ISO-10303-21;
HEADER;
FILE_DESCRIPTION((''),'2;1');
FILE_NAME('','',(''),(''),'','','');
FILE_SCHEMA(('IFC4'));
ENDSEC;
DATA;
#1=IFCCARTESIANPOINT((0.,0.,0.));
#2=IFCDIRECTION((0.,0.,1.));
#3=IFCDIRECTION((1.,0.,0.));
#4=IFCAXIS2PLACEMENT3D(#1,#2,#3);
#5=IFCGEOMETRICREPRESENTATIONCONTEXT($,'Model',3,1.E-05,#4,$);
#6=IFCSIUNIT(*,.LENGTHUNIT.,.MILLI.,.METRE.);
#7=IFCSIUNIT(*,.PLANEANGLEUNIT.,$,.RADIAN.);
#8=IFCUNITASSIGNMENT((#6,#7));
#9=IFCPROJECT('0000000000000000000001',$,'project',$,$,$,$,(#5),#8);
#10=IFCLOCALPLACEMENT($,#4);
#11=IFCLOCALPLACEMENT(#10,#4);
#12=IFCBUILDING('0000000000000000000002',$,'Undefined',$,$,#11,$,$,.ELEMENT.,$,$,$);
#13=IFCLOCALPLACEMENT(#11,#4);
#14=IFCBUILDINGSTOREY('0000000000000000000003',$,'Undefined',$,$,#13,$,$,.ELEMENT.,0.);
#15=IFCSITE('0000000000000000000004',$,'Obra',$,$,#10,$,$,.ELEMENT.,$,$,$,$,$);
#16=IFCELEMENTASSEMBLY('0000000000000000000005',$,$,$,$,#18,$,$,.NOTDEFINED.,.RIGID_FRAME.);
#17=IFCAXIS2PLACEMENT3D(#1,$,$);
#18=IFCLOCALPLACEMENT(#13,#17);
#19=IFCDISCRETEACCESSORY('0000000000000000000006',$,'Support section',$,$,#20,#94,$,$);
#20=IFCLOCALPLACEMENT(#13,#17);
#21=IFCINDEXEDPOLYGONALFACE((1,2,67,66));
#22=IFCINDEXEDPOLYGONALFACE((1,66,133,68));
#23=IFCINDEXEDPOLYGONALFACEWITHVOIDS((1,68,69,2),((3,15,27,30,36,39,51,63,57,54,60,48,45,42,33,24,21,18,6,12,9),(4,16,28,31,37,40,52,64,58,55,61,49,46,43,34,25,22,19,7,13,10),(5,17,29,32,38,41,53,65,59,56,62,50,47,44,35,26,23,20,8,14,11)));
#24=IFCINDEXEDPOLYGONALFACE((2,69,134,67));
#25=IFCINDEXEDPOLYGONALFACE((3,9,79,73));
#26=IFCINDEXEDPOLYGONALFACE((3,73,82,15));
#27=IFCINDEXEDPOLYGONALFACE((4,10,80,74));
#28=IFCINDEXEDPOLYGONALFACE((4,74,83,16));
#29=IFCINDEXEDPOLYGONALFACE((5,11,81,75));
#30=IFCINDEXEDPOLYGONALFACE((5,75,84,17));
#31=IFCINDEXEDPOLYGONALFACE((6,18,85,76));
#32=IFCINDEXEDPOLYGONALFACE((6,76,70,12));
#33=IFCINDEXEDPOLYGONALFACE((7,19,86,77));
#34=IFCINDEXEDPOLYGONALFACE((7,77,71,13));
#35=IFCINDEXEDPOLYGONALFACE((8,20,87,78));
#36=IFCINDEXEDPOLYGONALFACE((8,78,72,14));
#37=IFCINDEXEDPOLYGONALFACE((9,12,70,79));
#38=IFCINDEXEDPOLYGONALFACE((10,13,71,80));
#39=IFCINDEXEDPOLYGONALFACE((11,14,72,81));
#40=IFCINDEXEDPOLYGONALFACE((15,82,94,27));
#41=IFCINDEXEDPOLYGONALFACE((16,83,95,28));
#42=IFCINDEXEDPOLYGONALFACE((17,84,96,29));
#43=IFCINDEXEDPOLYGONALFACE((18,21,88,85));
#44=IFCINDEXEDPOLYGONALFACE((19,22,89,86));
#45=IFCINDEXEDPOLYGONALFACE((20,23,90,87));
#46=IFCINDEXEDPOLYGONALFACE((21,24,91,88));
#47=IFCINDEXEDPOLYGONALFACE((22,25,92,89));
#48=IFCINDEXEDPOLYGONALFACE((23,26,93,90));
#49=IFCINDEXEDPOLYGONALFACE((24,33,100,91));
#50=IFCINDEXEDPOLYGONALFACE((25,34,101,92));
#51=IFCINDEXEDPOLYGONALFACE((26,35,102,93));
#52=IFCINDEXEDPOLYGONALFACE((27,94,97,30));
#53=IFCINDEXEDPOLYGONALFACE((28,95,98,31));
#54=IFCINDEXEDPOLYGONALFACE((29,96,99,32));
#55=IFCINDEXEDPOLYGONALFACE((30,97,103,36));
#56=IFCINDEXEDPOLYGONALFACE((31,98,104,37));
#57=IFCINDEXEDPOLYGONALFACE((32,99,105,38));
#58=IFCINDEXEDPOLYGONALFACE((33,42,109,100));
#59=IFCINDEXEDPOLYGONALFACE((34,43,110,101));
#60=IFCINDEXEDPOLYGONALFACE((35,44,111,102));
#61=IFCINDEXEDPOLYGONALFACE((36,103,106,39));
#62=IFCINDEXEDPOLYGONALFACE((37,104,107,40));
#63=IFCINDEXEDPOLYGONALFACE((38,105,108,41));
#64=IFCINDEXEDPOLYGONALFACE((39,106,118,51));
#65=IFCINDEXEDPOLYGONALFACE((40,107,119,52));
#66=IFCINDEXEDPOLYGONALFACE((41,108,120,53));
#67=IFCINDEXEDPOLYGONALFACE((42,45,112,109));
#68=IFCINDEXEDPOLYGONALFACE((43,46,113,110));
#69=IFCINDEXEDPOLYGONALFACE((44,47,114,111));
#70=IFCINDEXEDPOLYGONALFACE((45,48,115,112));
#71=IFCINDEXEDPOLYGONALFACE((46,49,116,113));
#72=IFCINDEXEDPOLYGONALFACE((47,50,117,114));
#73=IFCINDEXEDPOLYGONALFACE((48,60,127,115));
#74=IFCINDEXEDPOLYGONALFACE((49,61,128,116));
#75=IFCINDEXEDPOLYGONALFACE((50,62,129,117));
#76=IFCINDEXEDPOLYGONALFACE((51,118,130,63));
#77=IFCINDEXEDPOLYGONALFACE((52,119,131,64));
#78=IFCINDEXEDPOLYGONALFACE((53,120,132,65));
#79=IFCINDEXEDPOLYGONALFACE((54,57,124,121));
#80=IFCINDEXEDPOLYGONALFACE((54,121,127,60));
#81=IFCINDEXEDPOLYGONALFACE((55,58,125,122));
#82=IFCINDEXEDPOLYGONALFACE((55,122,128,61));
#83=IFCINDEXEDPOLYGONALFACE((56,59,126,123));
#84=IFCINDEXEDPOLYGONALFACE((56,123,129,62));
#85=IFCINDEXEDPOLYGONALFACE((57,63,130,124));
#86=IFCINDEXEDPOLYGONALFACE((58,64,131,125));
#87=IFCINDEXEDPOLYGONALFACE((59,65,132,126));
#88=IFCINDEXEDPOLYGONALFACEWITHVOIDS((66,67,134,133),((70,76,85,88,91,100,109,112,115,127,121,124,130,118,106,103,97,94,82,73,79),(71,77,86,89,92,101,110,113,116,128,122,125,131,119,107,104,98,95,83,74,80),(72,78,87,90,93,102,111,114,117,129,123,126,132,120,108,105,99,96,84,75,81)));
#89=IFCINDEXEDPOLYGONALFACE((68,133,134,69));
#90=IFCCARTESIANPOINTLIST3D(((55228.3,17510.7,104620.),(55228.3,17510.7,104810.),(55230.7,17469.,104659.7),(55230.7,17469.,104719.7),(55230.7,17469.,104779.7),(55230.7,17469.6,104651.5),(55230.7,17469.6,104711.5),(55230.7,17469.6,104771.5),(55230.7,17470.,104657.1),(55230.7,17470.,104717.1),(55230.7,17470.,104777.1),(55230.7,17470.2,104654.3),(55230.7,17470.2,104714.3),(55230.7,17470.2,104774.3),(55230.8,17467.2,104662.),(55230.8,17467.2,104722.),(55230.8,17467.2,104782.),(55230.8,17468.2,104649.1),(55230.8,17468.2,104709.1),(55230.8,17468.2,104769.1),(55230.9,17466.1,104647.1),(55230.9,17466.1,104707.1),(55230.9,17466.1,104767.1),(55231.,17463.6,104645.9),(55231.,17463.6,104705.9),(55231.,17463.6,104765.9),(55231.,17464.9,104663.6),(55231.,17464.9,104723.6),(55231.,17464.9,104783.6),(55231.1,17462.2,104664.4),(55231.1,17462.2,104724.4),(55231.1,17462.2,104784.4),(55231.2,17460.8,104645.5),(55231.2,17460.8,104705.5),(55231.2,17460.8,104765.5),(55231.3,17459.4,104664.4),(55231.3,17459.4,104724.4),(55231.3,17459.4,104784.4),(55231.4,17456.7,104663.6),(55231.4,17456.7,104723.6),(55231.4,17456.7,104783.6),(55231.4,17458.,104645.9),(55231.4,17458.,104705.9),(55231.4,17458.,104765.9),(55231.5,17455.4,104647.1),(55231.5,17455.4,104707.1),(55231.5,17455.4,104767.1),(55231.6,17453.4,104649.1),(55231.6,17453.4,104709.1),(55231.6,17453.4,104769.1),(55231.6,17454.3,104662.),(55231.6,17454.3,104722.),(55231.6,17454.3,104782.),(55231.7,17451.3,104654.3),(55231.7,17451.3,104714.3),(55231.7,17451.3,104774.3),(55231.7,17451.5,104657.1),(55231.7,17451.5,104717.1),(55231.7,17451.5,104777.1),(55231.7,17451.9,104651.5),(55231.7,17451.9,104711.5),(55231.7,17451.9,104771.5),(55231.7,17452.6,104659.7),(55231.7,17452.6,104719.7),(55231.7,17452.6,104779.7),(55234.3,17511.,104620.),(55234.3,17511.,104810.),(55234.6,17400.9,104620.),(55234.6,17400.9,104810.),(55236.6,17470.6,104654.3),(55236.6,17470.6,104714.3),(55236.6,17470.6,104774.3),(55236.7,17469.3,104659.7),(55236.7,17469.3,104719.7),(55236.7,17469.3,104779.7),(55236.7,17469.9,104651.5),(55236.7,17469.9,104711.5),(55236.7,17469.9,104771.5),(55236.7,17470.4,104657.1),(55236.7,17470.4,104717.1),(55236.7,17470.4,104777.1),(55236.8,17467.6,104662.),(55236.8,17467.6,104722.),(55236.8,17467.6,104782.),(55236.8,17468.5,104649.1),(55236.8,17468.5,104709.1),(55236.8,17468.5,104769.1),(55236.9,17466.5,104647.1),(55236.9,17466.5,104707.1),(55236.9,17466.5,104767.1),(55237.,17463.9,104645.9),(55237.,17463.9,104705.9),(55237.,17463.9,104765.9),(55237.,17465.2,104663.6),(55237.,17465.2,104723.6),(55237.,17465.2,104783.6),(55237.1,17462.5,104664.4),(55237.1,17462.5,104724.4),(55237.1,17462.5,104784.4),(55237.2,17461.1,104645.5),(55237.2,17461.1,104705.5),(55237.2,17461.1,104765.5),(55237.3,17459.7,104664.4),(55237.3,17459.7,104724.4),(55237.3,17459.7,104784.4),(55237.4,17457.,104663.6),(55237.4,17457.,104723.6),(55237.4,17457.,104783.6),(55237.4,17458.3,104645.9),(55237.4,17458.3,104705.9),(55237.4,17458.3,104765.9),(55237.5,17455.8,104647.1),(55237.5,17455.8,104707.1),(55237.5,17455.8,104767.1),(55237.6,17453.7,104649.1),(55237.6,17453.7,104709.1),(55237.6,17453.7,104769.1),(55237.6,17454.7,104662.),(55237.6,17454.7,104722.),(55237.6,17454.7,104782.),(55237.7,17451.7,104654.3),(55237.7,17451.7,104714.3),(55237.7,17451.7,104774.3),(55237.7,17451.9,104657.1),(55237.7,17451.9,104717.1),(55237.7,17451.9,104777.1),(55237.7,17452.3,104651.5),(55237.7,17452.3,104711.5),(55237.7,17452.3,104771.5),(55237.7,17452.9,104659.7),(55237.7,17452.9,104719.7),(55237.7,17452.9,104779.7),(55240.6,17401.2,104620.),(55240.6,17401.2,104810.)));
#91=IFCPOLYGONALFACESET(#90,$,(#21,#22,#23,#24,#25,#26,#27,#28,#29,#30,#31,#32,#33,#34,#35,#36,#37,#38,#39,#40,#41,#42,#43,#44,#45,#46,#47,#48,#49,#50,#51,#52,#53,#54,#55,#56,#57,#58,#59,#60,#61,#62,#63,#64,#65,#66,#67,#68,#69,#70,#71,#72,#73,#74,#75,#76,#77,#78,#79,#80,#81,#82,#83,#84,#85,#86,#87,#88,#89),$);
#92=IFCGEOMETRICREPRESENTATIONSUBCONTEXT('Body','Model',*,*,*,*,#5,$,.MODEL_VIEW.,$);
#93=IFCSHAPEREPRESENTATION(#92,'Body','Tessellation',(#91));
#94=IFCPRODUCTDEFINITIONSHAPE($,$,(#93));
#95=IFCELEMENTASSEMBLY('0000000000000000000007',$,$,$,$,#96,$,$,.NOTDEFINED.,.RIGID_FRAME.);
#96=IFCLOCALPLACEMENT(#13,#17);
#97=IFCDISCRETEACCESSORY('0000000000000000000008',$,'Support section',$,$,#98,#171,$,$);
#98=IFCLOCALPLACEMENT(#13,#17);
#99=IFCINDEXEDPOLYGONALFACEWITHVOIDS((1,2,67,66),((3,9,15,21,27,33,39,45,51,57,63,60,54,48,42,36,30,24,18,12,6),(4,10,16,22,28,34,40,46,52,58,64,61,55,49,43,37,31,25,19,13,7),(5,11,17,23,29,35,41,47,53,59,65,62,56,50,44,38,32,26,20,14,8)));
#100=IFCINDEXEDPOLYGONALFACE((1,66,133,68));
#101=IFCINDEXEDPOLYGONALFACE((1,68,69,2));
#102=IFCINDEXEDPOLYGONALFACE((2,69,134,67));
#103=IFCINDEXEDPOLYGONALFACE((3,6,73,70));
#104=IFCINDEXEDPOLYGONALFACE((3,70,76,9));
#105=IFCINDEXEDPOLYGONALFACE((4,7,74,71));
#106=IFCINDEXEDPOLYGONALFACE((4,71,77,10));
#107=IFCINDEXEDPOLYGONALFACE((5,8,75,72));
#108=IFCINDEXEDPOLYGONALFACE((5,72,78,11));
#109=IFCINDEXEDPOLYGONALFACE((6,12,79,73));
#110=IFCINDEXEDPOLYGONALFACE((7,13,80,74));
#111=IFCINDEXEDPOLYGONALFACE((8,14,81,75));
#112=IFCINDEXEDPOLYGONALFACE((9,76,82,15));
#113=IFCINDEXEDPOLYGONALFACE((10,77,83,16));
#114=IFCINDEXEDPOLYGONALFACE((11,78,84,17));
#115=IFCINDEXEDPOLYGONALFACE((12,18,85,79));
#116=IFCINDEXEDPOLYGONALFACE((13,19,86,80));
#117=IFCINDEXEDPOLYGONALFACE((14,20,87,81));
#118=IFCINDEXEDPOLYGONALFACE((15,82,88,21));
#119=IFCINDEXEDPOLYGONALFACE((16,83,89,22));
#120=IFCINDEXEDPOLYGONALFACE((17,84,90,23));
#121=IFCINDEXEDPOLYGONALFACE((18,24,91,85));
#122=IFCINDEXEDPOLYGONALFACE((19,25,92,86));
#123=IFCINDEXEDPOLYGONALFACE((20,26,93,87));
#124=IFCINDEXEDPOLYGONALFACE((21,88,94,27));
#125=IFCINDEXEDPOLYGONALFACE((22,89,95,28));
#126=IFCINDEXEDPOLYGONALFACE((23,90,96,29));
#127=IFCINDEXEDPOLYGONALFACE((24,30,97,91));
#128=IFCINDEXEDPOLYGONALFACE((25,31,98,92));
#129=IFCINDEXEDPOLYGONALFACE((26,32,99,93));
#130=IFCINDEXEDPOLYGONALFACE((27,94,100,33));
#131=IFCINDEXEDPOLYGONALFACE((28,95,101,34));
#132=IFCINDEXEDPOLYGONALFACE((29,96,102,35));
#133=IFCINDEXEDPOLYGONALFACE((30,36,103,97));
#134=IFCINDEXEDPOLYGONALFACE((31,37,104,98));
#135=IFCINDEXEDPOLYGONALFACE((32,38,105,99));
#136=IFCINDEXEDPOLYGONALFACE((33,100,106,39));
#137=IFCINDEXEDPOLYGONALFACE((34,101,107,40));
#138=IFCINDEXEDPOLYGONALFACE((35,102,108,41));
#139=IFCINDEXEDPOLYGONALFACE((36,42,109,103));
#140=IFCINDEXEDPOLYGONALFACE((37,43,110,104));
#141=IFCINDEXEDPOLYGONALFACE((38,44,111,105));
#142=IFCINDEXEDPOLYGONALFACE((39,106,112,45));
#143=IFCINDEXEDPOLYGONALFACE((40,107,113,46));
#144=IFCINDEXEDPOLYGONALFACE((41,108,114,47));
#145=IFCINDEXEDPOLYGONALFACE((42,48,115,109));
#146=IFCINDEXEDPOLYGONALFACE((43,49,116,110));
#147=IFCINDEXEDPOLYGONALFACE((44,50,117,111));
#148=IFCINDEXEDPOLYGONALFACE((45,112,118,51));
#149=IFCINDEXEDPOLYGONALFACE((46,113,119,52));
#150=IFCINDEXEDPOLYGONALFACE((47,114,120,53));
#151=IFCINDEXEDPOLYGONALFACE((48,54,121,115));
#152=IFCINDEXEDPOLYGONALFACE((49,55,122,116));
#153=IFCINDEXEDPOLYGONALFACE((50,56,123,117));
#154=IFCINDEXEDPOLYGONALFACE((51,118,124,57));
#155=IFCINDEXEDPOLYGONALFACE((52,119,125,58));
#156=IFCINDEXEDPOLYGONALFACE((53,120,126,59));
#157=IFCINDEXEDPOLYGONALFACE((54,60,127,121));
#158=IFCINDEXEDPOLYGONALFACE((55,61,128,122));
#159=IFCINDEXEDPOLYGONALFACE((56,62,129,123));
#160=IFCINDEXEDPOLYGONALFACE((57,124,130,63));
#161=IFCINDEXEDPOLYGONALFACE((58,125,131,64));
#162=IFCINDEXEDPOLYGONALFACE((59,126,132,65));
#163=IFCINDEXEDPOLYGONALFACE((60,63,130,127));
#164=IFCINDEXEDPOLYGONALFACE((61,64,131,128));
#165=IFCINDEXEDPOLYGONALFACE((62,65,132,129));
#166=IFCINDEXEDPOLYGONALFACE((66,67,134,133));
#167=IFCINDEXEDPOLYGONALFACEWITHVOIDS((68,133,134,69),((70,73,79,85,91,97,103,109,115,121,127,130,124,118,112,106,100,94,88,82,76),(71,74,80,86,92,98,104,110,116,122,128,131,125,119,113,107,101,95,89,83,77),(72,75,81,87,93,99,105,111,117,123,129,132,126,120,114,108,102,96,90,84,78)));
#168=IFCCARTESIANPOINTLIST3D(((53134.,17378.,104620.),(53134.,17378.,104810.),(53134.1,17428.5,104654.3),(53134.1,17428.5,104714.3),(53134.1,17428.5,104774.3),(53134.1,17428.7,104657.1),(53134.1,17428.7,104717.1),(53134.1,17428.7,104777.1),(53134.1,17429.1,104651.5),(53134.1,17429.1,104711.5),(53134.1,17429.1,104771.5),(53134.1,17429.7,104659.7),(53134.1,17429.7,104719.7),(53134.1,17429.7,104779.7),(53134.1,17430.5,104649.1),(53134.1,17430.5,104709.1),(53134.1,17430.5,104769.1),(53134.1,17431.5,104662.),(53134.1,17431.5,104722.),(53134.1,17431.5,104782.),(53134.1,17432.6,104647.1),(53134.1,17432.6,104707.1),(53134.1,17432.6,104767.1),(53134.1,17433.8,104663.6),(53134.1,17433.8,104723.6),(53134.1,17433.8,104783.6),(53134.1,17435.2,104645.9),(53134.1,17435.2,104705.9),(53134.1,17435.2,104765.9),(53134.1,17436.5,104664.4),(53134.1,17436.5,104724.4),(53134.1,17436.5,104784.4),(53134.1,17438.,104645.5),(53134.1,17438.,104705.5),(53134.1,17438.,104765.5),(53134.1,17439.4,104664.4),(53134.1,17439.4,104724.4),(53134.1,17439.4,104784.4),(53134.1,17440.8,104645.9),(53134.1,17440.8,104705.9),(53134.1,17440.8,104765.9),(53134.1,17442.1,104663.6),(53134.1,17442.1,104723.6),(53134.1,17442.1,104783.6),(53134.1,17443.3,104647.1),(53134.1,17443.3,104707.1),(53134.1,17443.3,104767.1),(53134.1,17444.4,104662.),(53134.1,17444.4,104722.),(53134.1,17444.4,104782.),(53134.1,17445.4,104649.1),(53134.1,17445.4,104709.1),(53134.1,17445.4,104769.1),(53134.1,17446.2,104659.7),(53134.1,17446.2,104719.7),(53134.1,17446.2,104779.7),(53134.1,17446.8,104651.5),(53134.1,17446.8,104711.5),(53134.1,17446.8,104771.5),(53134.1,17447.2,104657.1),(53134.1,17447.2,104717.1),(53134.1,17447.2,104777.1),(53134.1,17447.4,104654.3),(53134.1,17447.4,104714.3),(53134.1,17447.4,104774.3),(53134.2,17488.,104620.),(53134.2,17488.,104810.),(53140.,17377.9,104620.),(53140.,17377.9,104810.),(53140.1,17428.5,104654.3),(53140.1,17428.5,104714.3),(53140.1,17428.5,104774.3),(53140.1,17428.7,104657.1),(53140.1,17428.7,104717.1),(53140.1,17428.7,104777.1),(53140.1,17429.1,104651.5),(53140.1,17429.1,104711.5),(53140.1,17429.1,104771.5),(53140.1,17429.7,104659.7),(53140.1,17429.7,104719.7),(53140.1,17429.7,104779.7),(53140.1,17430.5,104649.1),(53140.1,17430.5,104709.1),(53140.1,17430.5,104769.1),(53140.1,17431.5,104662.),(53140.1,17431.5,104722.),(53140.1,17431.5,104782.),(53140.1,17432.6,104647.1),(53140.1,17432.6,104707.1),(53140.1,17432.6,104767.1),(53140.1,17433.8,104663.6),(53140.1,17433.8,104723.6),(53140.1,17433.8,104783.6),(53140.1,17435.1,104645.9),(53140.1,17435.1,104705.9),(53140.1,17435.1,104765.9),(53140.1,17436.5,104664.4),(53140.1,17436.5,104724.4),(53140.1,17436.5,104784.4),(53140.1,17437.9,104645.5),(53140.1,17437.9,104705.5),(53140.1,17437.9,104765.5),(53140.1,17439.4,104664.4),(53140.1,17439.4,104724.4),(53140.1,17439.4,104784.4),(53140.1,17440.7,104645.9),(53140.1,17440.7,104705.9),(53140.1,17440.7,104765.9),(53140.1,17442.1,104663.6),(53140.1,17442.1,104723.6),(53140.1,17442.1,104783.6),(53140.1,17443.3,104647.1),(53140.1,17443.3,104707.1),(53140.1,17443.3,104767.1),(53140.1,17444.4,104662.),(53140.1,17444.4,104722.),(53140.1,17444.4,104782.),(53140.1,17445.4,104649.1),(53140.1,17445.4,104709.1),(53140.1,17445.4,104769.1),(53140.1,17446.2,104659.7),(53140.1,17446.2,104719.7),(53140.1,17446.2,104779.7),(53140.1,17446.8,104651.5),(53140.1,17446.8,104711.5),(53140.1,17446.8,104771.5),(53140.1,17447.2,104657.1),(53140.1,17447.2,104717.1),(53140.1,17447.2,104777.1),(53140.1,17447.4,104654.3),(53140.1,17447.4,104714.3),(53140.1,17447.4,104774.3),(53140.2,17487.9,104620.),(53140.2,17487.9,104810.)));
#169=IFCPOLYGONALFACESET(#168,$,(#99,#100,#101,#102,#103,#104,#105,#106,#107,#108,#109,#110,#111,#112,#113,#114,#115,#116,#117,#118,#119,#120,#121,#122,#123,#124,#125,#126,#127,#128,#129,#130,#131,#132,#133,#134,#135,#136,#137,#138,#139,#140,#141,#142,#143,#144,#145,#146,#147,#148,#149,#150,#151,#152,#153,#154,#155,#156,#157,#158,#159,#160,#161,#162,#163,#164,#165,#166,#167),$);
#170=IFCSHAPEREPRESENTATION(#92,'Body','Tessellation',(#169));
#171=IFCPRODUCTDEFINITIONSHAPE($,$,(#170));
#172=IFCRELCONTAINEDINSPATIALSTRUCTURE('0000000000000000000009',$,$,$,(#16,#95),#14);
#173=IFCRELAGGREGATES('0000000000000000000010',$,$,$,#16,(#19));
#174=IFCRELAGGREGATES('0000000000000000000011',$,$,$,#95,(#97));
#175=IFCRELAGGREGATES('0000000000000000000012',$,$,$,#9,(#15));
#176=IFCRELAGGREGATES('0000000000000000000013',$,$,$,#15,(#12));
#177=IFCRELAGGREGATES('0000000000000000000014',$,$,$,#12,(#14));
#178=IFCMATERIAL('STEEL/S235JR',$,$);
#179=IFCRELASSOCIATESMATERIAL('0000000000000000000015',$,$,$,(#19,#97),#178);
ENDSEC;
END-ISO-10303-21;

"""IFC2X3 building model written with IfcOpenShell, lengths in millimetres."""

from ifc_helpers import new_model, si_unit, frame, origin_with_axes, origin_2d_with_axis, place, context, subcontext, project, spatial, rectangle, circle, extrude, source, transform, mapped, material, element, aggregate, save


model = new_model("IFC2X3")

# Units and contexts
model_context = context("Model", 3, precision=1e-05, world=origin_with_axes())
body_context = subcontext(model_context, "Body", "Model", "MODEL_VIEW")
ifc_project = project(units=[si_unit("LENGTHUNIT", "METRE", prefix="MILLI"), si_unit("PLANEANGLEUNIT", "RADIAN")], contexts=[model_context])

# Site, building, storey
site_placement = place(None, origin_with_axes())
site = spatial("IfcSite", under=ifc_project, at=site_placement, Name="Obra", CompositionType="ELEMENT")
building_placement = place(site_placement, origin_with_axes())
building = spatial("IfcBuilding", under=site, at=building_placement, Name="Undefined", CompositionType="ELEMENT")
storey_placement = place(building_placement, origin_with_axes())
storey = spatial("IfcBuildingStorey", under=building, at=storey_placement, Name="Undefined", CompositionType="ELEMENT", Elevation=0.0)

# Shared definitions
ifc_material = material(Name="STEEL/S235JR")

# Element assemblies, discrete accessories, openings
shared_shape_1 = source(origin_with_axes(), body_context, "Body", "SweptSolid", [
    extrude(circle(Radius=9.5, at=origin_2d_with_axis()), frame((0.0, -9.2, 0.0), z_axis=(0.0, 1.0, 0.0), x_axis=(1.0, 0.0, 0.0)), (0.0, 0.0, 1.0), 6.2),
])
assembly_1_placement = place(storey_placement, origin_with_axes())
assembly_1 = element("IfcElementAssembly", 1, at=assembly_1_placement, inside=storey, AssemblyPlace="NOTDEFINED", PredefinedType="RIGID_FRAME")
discrete_accessory_1_placement = place(assembly_1_placement, frame((55234.5, 17456.0, 104620.0), z_axis=(0.0, 0.0, 1.0), x_axis=(0.057107, -0.998368, 0.0)))
discrete_accessory_1 = element("IfcDiscreteAccessory", 2, at=discrete_accessory_1_placement, material=ifc_material, Name="Support section", context=body_context, shape_type="SweptSolid", body=[
    extrude(rectangle(XDim=6.0, YDim=110.0, at=origin_2d_with_axis()), frame((0.0, 0.0, 190.0), z_axis=(0.0, 0.0, -1.0), x_axis=(0.0, 1.0, 0.0)), (0.0, 0.0, 1.0), 190.0),
])
opening_1_placement = place(assembly_1_placement, frame((55231.0, 17410.7, 104835.0), z_axis=(-0.057107, 0.998368, 0.0), x_axis=(0.0, 0.0, -1.0)))
element("IfcOpeningElement", 3, at=opening_1_placement, cuts=discrete_accessory_1, ObjectType="Opening", context=body_context, shape_type="MappedRepresentation", body=[
    mapped(shared_shape_1, transform((60.0, 0.0, 50.0))),
    mapped(shared_shape_1, transform((120.0, 0.0, 50.0))),
    mapped(shared_shape_1, transform((180.0, 0.0, 50.0))),
])
aggregate(assembly_1, [discrete_accessory_1])
assembly_2_placement = place(storey_placement, origin_with_axes())
assembly_2 = element("IfcElementAssembly", 4, at=assembly_2_placement, inside=storey, AssemblyPlace="NOTDEFINED", PredefinedType="RIGID_FRAME")
discrete_accessory_2_placement = place(assembly_2_placement, frame((53137.1, 17433.0, 104620.0), z_axis=(0.0, 0.0, 1.0), x_axis=(-0.001649, -0.999999, 0.0)))
discrete_accessory_2 = element("IfcDiscreteAccessory", 5, at=discrete_accessory_2_placement, material=ifc_material, Name="Support section", context=body_context, shape_type="SweptSolid", body=[
    extrude(rectangle(XDim=6.0, YDim=110.0, at=origin_2d_with_axis()), frame((0.0, 0.0, 190.0), z_axis=(0.0, 0.0, -1.0), x_axis=(0.0, 1.0, 0.0)), (0.0, 0.0, 1.0), 190.0),
])
opening_2_placement = place(assembly_2_placement, frame((53130.9, 17388.0, 104835.0), z_axis=(0.001649, 0.999999, 0.0), x_axis=(0.0, 0.0, -1.0)))
element("IfcOpeningElement", 6, at=opening_2_placement, cuts=discrete_accessory_2, ObjectType="Opening", context=body_context, shape_type="MappedRepresentation", body=[
    mapped(shared_shape_1, transform((60.0, 0.0, 50.0))),
    mapped(shared_shape_1, transform((120.0, 0.0, 50.0))),
    mapped(shared_shape_1, transform((180.0, 0.0, 50.0))),
])
aggregate(assembly_2, [discrete_accessory_2])

save(model, "model.ifc")
